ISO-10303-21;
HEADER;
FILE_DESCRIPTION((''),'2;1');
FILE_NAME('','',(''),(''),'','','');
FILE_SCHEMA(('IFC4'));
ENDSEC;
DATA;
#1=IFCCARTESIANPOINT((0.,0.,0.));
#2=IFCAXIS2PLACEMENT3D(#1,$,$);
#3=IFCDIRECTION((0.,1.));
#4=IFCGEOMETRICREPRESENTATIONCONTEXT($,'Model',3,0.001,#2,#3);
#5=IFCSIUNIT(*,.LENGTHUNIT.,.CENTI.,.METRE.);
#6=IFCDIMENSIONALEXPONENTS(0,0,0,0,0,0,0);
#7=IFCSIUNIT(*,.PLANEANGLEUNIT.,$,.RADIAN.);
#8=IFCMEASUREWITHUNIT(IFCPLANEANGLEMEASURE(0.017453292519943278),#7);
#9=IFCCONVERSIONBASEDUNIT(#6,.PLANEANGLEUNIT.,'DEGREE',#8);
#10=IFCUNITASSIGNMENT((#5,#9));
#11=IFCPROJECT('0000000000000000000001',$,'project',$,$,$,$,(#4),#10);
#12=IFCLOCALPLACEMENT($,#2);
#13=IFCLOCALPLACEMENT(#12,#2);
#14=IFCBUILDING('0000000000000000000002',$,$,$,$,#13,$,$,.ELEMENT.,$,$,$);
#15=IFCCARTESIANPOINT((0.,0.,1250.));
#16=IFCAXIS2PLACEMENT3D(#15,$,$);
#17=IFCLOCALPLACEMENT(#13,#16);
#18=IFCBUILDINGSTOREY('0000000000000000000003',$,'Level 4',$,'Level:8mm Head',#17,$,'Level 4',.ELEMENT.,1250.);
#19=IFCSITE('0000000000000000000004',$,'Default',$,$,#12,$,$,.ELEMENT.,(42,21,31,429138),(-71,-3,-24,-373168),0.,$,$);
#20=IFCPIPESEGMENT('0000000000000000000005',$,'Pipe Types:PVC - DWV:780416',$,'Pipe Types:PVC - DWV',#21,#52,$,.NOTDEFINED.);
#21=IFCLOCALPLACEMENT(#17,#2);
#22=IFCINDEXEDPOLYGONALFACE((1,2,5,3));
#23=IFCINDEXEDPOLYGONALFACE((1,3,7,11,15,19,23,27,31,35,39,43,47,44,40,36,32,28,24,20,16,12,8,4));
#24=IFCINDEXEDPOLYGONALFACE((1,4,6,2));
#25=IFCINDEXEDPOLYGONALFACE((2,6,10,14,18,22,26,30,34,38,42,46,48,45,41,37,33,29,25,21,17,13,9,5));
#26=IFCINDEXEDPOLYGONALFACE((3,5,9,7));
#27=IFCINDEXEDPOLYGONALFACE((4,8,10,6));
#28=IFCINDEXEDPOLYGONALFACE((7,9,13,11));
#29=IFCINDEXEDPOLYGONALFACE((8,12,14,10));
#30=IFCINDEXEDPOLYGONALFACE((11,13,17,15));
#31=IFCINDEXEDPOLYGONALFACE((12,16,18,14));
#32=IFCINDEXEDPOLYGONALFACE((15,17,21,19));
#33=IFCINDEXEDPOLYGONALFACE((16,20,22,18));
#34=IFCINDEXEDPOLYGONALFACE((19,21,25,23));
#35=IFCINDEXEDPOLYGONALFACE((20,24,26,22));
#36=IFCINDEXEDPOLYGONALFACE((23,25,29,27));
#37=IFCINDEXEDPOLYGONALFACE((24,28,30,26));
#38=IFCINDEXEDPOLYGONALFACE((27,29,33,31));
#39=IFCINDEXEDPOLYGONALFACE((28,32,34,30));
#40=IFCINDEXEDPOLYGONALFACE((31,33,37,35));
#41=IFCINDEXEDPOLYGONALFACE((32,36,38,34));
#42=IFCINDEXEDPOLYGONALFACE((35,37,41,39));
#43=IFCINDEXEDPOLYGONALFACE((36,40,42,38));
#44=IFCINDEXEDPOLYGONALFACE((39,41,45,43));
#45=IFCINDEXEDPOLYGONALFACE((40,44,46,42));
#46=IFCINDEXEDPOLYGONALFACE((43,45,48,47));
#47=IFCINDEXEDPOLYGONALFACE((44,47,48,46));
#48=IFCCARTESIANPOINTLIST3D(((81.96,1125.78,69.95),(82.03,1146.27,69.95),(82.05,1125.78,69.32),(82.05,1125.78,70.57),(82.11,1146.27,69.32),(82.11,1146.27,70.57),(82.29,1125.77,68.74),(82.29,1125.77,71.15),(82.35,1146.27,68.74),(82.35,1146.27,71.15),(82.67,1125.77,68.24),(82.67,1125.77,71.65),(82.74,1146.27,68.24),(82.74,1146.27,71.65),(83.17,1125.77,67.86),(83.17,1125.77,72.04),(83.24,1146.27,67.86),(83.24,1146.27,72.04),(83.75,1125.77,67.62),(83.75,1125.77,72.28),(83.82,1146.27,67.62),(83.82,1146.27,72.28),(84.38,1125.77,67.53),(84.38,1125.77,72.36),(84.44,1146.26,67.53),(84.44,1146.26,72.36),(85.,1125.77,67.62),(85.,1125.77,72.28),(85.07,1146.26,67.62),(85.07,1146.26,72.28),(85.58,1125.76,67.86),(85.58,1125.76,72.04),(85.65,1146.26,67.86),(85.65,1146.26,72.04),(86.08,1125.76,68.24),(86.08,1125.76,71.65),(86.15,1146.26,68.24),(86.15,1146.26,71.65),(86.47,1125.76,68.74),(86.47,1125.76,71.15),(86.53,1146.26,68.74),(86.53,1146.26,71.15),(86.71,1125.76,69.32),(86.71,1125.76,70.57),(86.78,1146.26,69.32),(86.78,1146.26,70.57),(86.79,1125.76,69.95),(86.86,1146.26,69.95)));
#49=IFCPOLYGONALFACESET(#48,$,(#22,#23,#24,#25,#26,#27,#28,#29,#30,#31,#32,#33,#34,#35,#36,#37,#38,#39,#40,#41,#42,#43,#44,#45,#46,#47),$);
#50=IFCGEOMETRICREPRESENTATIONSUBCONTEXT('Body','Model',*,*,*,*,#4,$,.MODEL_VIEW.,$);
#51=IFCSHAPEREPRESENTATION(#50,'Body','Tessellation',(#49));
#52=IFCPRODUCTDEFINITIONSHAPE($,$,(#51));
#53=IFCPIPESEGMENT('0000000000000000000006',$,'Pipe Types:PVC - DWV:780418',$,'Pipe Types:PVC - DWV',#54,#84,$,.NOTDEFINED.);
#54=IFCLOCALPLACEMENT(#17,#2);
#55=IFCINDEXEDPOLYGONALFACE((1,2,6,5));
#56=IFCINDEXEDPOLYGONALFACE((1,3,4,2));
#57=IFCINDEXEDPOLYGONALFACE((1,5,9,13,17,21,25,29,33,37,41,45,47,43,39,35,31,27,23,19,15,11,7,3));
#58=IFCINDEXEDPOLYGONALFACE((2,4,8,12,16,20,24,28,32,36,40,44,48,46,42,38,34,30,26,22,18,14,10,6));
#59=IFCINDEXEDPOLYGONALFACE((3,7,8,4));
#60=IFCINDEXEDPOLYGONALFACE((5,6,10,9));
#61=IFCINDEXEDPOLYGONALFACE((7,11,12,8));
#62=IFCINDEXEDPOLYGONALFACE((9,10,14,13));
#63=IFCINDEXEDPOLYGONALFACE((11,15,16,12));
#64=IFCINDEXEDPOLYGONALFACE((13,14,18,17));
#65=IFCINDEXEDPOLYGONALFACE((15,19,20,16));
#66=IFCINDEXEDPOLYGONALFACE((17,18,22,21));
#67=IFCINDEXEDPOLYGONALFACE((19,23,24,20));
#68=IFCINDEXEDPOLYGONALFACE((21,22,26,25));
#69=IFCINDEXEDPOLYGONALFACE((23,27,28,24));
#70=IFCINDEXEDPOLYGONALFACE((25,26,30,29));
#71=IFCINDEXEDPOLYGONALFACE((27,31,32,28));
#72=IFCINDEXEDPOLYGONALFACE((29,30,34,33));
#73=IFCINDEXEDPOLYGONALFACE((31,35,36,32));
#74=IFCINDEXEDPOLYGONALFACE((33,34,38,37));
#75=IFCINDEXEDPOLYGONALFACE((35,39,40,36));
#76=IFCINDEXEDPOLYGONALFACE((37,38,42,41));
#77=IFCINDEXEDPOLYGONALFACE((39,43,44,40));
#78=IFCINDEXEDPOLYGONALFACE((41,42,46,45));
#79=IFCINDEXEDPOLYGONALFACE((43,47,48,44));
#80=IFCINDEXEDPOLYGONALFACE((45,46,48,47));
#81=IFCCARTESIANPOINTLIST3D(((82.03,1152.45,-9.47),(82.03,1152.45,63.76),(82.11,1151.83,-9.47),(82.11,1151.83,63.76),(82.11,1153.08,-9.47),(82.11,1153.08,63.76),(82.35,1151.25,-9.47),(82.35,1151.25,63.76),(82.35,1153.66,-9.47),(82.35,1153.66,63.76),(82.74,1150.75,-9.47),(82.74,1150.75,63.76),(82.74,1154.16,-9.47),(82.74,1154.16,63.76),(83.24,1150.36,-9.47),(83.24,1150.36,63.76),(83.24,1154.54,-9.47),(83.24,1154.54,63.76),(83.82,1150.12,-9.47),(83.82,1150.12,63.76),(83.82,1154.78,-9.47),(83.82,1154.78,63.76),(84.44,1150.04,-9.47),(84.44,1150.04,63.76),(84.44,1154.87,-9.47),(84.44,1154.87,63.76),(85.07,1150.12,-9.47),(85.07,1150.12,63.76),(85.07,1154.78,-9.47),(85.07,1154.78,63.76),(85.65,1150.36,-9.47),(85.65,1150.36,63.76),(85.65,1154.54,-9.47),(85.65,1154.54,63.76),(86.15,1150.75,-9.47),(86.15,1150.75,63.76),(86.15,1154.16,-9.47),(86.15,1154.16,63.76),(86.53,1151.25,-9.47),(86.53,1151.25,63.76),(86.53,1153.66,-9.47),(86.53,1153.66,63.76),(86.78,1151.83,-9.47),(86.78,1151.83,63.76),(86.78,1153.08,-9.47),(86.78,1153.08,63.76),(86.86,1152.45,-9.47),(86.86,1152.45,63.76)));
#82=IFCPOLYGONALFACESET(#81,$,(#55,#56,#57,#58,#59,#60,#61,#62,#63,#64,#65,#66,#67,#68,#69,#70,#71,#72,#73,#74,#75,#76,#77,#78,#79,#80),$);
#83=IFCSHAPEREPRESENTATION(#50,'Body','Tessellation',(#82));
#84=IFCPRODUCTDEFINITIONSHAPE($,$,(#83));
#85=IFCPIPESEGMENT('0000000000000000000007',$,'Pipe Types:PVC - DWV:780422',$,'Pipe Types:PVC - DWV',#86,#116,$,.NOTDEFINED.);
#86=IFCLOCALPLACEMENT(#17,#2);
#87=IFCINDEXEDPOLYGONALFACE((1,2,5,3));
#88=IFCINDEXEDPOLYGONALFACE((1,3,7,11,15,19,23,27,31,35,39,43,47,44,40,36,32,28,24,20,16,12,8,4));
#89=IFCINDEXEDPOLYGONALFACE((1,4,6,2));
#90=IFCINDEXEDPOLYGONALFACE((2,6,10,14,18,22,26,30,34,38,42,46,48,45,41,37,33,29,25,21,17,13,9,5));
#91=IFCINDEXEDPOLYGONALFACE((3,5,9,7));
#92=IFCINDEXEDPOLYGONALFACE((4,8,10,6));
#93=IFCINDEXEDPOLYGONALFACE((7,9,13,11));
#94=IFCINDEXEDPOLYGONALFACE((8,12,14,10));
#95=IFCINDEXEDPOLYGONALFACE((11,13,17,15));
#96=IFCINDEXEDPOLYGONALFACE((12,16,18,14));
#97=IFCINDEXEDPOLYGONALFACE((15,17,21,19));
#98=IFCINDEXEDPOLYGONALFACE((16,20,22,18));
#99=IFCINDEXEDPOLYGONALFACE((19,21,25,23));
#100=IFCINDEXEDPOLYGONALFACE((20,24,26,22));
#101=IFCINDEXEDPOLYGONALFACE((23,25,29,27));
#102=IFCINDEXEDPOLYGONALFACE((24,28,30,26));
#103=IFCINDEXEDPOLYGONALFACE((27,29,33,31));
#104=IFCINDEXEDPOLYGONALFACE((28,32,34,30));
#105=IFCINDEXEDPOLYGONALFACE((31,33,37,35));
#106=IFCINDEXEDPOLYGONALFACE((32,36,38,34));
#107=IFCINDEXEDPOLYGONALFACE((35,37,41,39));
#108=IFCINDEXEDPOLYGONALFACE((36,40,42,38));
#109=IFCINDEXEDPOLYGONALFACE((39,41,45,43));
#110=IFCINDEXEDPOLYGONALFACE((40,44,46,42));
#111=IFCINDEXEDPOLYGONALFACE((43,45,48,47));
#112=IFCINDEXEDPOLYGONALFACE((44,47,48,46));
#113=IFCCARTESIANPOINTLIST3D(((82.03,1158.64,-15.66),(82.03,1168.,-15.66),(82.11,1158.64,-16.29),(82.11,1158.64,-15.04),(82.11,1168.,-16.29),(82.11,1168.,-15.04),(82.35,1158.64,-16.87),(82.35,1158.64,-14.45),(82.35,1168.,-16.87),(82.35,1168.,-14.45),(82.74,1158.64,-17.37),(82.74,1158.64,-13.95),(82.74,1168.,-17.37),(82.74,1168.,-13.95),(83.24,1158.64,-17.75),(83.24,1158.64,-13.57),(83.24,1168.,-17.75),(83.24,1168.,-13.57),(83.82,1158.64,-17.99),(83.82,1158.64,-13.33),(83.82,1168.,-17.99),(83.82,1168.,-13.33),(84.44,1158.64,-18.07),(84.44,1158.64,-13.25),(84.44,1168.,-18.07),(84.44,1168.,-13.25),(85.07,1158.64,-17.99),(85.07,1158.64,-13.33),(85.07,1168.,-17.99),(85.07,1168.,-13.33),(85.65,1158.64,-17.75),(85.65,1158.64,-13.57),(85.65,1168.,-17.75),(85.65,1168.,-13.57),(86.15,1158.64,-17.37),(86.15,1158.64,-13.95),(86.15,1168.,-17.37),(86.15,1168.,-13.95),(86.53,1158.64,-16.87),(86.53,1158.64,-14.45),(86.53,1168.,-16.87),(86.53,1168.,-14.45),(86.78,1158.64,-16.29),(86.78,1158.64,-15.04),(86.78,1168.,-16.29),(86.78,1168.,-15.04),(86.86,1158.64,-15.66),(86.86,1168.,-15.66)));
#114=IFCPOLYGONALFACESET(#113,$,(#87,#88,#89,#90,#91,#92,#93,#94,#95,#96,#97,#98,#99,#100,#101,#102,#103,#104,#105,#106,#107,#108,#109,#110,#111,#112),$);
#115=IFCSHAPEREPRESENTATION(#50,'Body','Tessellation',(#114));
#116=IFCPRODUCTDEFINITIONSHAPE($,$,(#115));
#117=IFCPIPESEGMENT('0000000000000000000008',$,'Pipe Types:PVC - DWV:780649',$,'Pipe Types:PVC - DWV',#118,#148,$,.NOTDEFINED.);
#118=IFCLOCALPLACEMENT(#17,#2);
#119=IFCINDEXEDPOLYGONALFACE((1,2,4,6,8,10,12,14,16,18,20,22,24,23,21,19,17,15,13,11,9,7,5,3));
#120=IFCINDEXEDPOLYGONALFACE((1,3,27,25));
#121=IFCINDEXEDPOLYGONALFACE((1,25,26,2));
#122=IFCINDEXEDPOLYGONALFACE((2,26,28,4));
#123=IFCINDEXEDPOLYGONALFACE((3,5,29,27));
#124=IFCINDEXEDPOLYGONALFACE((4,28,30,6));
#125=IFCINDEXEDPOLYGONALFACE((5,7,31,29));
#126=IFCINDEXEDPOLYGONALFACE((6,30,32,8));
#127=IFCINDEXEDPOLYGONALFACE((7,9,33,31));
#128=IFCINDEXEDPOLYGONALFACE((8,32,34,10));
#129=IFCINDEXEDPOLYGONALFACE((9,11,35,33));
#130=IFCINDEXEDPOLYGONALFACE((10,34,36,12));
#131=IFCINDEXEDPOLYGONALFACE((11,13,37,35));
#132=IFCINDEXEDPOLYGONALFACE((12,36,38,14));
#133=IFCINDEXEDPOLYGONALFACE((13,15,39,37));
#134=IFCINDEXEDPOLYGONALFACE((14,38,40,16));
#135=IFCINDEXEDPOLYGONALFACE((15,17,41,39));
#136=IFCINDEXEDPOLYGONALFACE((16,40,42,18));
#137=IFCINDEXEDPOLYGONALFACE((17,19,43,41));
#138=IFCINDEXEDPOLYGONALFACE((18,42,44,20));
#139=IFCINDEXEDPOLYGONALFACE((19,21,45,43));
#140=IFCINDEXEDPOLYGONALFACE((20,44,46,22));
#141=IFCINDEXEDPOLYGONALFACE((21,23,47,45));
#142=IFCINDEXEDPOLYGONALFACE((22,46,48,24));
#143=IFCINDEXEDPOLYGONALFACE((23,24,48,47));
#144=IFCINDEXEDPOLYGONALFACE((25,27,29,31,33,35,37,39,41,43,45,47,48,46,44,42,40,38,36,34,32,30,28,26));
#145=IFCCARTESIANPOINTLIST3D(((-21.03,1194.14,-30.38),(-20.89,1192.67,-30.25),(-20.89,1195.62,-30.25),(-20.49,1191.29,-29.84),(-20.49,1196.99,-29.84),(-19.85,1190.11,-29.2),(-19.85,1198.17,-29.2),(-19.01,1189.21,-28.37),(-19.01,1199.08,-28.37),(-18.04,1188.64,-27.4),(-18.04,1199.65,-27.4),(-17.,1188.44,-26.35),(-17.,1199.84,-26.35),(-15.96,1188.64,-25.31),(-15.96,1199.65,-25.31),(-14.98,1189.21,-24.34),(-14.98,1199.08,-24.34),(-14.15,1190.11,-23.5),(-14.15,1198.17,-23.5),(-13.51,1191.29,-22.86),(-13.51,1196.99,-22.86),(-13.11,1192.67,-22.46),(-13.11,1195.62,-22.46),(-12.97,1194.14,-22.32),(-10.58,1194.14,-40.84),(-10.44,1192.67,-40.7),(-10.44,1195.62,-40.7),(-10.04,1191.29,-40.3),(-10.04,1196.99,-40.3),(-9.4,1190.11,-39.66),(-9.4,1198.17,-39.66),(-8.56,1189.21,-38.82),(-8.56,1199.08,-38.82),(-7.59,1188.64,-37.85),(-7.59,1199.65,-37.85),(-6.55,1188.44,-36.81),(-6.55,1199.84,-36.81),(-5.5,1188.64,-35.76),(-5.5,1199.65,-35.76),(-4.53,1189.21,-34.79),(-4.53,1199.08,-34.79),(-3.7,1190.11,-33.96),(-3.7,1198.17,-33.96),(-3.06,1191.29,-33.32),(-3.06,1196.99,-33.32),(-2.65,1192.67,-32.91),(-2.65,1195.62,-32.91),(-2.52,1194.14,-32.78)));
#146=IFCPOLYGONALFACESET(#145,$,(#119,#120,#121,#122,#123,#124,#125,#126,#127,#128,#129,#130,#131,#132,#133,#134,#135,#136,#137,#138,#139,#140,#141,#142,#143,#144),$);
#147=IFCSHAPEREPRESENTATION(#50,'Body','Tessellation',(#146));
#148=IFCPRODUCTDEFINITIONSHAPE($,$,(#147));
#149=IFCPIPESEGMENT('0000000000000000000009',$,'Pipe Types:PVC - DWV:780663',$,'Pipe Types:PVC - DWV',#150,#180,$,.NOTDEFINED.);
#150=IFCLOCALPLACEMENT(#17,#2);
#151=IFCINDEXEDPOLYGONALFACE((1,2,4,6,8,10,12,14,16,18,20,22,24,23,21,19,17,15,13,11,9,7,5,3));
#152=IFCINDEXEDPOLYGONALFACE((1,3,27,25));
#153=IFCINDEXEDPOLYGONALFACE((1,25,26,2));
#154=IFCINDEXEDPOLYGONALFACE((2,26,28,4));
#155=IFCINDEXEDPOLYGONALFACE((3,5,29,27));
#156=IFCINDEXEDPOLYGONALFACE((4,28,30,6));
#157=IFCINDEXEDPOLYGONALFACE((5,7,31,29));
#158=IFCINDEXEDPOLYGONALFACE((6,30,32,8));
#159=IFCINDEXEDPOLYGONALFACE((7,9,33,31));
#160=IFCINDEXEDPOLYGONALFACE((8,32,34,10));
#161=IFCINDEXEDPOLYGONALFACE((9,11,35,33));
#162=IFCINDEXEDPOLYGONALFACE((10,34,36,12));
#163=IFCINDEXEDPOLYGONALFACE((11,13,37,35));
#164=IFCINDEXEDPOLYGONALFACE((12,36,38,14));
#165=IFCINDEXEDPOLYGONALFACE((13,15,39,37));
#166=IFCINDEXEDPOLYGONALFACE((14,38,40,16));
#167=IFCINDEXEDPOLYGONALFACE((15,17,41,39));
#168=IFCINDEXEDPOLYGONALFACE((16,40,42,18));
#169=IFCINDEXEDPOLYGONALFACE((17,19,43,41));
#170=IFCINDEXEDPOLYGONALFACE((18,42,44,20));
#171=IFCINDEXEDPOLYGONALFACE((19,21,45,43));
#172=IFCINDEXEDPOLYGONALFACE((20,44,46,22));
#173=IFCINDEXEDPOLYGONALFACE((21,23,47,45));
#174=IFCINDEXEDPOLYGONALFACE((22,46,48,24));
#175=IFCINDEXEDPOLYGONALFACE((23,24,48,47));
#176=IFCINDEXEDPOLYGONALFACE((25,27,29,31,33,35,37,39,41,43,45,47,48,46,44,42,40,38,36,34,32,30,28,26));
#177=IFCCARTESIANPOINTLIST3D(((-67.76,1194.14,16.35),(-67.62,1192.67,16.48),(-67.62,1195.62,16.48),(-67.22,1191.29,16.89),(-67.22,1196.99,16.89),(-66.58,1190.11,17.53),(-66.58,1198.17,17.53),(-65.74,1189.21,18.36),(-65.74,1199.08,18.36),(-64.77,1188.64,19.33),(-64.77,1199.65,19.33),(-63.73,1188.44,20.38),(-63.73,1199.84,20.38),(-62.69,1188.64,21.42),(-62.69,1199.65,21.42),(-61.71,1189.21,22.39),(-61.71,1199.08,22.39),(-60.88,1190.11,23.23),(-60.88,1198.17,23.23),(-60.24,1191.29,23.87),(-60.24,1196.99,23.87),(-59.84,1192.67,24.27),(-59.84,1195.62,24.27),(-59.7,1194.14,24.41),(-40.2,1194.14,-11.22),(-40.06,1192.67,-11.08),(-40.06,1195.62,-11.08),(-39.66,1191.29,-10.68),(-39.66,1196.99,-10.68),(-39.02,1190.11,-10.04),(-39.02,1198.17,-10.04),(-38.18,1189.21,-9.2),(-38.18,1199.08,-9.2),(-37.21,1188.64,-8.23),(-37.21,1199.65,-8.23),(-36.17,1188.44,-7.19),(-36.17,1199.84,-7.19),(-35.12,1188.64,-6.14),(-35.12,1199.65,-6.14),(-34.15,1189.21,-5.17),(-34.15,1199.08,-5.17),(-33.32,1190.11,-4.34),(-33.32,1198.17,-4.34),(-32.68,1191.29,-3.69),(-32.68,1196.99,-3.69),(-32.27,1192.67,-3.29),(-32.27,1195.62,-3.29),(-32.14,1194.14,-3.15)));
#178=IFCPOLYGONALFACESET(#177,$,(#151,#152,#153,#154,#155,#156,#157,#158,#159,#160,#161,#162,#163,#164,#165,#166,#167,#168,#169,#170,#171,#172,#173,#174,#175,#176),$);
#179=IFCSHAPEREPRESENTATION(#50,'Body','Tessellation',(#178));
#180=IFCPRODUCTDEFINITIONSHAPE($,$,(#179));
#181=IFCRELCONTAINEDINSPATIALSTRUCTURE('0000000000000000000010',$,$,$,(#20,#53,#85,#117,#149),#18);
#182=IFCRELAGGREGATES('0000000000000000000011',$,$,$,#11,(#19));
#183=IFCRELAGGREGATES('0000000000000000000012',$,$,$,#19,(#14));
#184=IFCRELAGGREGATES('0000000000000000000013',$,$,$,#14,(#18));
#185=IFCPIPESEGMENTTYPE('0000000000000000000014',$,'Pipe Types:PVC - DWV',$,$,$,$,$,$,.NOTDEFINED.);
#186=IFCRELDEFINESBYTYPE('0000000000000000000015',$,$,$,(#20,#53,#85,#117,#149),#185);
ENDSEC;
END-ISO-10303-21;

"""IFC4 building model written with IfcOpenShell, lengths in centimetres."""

from ifc_helpers import new_model, entity, si_unit, converted_unit, direction, frame, origin, place, context, subcontext, project, spatial, arc, indexed_curve, outline, extrude, type_object, element, save


model = new_model("IFC4")

# Units and contexts
model_context = context("Model", 3, precision=0.001, world=origin(), true_north=direction((0.0, 1.0)))
body_context = subcontext(model_context, "Body", "Model", "MODEL_VIEW")
ifc_project = project(units=[si_unit("LENGTHUNIT", "METRE", prefix="CENTI"), converted_unit("PLANEANGLEUNIT", "DEGREE", entity("IfcPlaneAngleMeasure", 0.017453292519943278), si_unit("PLANEANGLEUNIT", "RADIAN"), dimensions=[0, 0, 0, 0, 0, 0, 0])], contexts=[model_context])

# Site, building, storey
site_placement = place(None, origin())
site = spatial("IfcSite", under=ifc_project, at=site_placement, Name="Default", CompositionType="ELEMENT", RefLatitude=(42, 21, 31, 429138), RefLongitude=(-71, -3, -24, -373168), RefElevation=0.0)
building_placement = place(site_placement, origin())
building = spatial("IfcBuilding", under=site, at=building_placement, CompositionType="ELEMENT")
storey_placement = place(building_placement, frame((0.0, 0.0, 1250.0)))
storey = spatial("IfcBuildingStorey", under=building, at=storey_placement, Name="Level 4", ObjectType="Level:8mm Head", LongName="Level 4", CompositionType="ELEMENT", Elevation=1250.0)

# Pipe segments
pipe_segment_type = type_object("IfcPipeSegmentType", Name="Pipe Types:PVC - DWV", PredefinedType="NOTDEFINED")
pipe_segment_1_placement = place(storey_placement, origin())
element("IfcPipeSegment", 1, at=pipe_segment_1_placement, inside=storey, type_object=pipe_segment_type, Name="Pipe Types:PVC - DWV:780416", ObjectType="Pipe Types:PVC - DWV", PredefinedType="NOTDEFINED", context=body_context, shape_type="SweptSolid", body=[
    extrude(outline(indexed_curve([(2.41, 0.0), (1.71, 1.71), (0.0, 2.41), (-1.71, 1.71), (-2.41, 0.0), (-1.71, -1.71), (0.0, -2.41), (1.71, -1.71)], segments=[arc(1, 2, 3), arc(3, 4, 5), arc(5, 6, 7), arc(7, 8, 1)], self_intersect=False)), frame((84.38, 1125.77, 69.95), z_axis=(0.003331, 0.999994, 0.0), x_axis=(0.999994, -0.003331, 0.0)), (0.0, 0.0, 1.0), 20.5),
])
pipe_segment_2_placement = place(storey_placement, origin())
element("IfcPipeSegment", 2, at=pipe_segment_2_placement, inside=storey, type_object=pipe_segment_type, Name="Pipe Types:PVC - DWV:780418", ObjectType="Pipe Types:PVC - DWV", PredefinedType="NOTDEFINED", context=body_context, shape_type="SweptSolid", body=[
    extrude(outline(indexed_curve([(2.41, 0.0), (1.71, 1.71), (0.0, 2.41), (-1.71, 1.71), (-2.41, 0.0), (-1.71, -1.71), (0.0, -2.41), (1.71, -1.71)], segments=[arc(1, 2, 3), arc(3, 4, 5), arc(5, 6, 7), arc(7, 8, 1)], self_intersect=False)), frame((84.44, 1152.45, -9.47)), (0.0, 0.0, 1.0), 73.23),
])
pipe_segment_3_placement = place(storey_placement, origin())
element("IfcPipeSegment", 3, at=pipe_segment_3_placement, inside=storey, type_object=pipe_segment_type, Name="Pipe Types:PVC - DWV:780422", ObjectType="Pipe Types:PVC - DWV", PredefinedType="NOTDEFINED", context=body_context, shape_type="SweptSolid", body=[
    extrude(outline(indexed_curve([(2.41, 0.0), (1.71, 1.71), (0.0, 2.41), (-1.71, 1.71), (-2.41, 0.0), (-1.71, -1.71), (0.0, -2.41), (1.71, -1.71)], segments=[arc(1, 2, 3), arc(3, 4, 5), arc(5, 6, 7), arc(7, 8, 1)], self_intersect=False)), frame((84.44, 1158.64, -15.66), z_axis=(0.0, 1.0, 0.0), x_axis=(1.0, 0.0, 0.0)), (0.0, 0.0, 1.0), 9.36),
])
pipe_segment_4_placement = place(storey_placement, origin())
element("IfcPipeSegment", 4, at=pipe_segment_4_placement, inside=storey, type_object=pipe_segment_type, Name="Pipe Types:PVC - DWV:780649", ObjectType="Pipe Types:PVC - DWV", PredefinedType="NOTDEFINED", context=body_context, shape_type="SweptSolid", body=[
    extrude(outline(indexed_curve([(5.7, 0.0), (4.03, 4.03), (0.0, 5.7), (-4.03, 4.03), (-5.7, 0.0), (-4.03, -4.03), (0.0, -5.7), (4.03, -4.03)], segments=[arc(1, 2, 3), arc(3, 4, 5), arc(5, 6, 7), arc(7, 8, 1)], self_intersect=False)), frame((-17.0, 1194.14, -26.35), z_axis=(0.707107, 0.0, -0.707107), x_axis=(0.0, -1.0, 0.0)), (0.0, 0.0, 1.0), 14.78),
])
pipe_segment_5_placement = place(storey_placement, origin())
element("IfcPipeSegment", 5, at=pipe_segment_5_placement, inside=storey, type_object=pipe_segment_type, Name="Pipe Types:PVC - DWV:780663", ObjectType="Pipe Types:PVC - DWV", PredefinedType="NOTDEFINED", context=body_context, shape_type="SweptSolid", body=[
    extrude(outline(indexed_curve([(5.7, 0.0), (4.03, 4.03), (0.0, 5.7), (-4.03, 4.03), (-5.7, 0.0), (-4.03, -4.03), (0.0, -5.7), (4.03, -4.03)], segments=[arc(1, 2, 3), arc(3, 4, 5), arc(5, 6, 7), arc(7, 8, 1)], self_intersect=False)), frame((-63.73, 1194.14, 20.38), z_axis=(0.707107, 0.0, -0.707107), x_axis=(0.0, -1.0, 0.0)), (0.0, 0.0, 1.0), 38.98),
])

save(model, "model.ifc")
